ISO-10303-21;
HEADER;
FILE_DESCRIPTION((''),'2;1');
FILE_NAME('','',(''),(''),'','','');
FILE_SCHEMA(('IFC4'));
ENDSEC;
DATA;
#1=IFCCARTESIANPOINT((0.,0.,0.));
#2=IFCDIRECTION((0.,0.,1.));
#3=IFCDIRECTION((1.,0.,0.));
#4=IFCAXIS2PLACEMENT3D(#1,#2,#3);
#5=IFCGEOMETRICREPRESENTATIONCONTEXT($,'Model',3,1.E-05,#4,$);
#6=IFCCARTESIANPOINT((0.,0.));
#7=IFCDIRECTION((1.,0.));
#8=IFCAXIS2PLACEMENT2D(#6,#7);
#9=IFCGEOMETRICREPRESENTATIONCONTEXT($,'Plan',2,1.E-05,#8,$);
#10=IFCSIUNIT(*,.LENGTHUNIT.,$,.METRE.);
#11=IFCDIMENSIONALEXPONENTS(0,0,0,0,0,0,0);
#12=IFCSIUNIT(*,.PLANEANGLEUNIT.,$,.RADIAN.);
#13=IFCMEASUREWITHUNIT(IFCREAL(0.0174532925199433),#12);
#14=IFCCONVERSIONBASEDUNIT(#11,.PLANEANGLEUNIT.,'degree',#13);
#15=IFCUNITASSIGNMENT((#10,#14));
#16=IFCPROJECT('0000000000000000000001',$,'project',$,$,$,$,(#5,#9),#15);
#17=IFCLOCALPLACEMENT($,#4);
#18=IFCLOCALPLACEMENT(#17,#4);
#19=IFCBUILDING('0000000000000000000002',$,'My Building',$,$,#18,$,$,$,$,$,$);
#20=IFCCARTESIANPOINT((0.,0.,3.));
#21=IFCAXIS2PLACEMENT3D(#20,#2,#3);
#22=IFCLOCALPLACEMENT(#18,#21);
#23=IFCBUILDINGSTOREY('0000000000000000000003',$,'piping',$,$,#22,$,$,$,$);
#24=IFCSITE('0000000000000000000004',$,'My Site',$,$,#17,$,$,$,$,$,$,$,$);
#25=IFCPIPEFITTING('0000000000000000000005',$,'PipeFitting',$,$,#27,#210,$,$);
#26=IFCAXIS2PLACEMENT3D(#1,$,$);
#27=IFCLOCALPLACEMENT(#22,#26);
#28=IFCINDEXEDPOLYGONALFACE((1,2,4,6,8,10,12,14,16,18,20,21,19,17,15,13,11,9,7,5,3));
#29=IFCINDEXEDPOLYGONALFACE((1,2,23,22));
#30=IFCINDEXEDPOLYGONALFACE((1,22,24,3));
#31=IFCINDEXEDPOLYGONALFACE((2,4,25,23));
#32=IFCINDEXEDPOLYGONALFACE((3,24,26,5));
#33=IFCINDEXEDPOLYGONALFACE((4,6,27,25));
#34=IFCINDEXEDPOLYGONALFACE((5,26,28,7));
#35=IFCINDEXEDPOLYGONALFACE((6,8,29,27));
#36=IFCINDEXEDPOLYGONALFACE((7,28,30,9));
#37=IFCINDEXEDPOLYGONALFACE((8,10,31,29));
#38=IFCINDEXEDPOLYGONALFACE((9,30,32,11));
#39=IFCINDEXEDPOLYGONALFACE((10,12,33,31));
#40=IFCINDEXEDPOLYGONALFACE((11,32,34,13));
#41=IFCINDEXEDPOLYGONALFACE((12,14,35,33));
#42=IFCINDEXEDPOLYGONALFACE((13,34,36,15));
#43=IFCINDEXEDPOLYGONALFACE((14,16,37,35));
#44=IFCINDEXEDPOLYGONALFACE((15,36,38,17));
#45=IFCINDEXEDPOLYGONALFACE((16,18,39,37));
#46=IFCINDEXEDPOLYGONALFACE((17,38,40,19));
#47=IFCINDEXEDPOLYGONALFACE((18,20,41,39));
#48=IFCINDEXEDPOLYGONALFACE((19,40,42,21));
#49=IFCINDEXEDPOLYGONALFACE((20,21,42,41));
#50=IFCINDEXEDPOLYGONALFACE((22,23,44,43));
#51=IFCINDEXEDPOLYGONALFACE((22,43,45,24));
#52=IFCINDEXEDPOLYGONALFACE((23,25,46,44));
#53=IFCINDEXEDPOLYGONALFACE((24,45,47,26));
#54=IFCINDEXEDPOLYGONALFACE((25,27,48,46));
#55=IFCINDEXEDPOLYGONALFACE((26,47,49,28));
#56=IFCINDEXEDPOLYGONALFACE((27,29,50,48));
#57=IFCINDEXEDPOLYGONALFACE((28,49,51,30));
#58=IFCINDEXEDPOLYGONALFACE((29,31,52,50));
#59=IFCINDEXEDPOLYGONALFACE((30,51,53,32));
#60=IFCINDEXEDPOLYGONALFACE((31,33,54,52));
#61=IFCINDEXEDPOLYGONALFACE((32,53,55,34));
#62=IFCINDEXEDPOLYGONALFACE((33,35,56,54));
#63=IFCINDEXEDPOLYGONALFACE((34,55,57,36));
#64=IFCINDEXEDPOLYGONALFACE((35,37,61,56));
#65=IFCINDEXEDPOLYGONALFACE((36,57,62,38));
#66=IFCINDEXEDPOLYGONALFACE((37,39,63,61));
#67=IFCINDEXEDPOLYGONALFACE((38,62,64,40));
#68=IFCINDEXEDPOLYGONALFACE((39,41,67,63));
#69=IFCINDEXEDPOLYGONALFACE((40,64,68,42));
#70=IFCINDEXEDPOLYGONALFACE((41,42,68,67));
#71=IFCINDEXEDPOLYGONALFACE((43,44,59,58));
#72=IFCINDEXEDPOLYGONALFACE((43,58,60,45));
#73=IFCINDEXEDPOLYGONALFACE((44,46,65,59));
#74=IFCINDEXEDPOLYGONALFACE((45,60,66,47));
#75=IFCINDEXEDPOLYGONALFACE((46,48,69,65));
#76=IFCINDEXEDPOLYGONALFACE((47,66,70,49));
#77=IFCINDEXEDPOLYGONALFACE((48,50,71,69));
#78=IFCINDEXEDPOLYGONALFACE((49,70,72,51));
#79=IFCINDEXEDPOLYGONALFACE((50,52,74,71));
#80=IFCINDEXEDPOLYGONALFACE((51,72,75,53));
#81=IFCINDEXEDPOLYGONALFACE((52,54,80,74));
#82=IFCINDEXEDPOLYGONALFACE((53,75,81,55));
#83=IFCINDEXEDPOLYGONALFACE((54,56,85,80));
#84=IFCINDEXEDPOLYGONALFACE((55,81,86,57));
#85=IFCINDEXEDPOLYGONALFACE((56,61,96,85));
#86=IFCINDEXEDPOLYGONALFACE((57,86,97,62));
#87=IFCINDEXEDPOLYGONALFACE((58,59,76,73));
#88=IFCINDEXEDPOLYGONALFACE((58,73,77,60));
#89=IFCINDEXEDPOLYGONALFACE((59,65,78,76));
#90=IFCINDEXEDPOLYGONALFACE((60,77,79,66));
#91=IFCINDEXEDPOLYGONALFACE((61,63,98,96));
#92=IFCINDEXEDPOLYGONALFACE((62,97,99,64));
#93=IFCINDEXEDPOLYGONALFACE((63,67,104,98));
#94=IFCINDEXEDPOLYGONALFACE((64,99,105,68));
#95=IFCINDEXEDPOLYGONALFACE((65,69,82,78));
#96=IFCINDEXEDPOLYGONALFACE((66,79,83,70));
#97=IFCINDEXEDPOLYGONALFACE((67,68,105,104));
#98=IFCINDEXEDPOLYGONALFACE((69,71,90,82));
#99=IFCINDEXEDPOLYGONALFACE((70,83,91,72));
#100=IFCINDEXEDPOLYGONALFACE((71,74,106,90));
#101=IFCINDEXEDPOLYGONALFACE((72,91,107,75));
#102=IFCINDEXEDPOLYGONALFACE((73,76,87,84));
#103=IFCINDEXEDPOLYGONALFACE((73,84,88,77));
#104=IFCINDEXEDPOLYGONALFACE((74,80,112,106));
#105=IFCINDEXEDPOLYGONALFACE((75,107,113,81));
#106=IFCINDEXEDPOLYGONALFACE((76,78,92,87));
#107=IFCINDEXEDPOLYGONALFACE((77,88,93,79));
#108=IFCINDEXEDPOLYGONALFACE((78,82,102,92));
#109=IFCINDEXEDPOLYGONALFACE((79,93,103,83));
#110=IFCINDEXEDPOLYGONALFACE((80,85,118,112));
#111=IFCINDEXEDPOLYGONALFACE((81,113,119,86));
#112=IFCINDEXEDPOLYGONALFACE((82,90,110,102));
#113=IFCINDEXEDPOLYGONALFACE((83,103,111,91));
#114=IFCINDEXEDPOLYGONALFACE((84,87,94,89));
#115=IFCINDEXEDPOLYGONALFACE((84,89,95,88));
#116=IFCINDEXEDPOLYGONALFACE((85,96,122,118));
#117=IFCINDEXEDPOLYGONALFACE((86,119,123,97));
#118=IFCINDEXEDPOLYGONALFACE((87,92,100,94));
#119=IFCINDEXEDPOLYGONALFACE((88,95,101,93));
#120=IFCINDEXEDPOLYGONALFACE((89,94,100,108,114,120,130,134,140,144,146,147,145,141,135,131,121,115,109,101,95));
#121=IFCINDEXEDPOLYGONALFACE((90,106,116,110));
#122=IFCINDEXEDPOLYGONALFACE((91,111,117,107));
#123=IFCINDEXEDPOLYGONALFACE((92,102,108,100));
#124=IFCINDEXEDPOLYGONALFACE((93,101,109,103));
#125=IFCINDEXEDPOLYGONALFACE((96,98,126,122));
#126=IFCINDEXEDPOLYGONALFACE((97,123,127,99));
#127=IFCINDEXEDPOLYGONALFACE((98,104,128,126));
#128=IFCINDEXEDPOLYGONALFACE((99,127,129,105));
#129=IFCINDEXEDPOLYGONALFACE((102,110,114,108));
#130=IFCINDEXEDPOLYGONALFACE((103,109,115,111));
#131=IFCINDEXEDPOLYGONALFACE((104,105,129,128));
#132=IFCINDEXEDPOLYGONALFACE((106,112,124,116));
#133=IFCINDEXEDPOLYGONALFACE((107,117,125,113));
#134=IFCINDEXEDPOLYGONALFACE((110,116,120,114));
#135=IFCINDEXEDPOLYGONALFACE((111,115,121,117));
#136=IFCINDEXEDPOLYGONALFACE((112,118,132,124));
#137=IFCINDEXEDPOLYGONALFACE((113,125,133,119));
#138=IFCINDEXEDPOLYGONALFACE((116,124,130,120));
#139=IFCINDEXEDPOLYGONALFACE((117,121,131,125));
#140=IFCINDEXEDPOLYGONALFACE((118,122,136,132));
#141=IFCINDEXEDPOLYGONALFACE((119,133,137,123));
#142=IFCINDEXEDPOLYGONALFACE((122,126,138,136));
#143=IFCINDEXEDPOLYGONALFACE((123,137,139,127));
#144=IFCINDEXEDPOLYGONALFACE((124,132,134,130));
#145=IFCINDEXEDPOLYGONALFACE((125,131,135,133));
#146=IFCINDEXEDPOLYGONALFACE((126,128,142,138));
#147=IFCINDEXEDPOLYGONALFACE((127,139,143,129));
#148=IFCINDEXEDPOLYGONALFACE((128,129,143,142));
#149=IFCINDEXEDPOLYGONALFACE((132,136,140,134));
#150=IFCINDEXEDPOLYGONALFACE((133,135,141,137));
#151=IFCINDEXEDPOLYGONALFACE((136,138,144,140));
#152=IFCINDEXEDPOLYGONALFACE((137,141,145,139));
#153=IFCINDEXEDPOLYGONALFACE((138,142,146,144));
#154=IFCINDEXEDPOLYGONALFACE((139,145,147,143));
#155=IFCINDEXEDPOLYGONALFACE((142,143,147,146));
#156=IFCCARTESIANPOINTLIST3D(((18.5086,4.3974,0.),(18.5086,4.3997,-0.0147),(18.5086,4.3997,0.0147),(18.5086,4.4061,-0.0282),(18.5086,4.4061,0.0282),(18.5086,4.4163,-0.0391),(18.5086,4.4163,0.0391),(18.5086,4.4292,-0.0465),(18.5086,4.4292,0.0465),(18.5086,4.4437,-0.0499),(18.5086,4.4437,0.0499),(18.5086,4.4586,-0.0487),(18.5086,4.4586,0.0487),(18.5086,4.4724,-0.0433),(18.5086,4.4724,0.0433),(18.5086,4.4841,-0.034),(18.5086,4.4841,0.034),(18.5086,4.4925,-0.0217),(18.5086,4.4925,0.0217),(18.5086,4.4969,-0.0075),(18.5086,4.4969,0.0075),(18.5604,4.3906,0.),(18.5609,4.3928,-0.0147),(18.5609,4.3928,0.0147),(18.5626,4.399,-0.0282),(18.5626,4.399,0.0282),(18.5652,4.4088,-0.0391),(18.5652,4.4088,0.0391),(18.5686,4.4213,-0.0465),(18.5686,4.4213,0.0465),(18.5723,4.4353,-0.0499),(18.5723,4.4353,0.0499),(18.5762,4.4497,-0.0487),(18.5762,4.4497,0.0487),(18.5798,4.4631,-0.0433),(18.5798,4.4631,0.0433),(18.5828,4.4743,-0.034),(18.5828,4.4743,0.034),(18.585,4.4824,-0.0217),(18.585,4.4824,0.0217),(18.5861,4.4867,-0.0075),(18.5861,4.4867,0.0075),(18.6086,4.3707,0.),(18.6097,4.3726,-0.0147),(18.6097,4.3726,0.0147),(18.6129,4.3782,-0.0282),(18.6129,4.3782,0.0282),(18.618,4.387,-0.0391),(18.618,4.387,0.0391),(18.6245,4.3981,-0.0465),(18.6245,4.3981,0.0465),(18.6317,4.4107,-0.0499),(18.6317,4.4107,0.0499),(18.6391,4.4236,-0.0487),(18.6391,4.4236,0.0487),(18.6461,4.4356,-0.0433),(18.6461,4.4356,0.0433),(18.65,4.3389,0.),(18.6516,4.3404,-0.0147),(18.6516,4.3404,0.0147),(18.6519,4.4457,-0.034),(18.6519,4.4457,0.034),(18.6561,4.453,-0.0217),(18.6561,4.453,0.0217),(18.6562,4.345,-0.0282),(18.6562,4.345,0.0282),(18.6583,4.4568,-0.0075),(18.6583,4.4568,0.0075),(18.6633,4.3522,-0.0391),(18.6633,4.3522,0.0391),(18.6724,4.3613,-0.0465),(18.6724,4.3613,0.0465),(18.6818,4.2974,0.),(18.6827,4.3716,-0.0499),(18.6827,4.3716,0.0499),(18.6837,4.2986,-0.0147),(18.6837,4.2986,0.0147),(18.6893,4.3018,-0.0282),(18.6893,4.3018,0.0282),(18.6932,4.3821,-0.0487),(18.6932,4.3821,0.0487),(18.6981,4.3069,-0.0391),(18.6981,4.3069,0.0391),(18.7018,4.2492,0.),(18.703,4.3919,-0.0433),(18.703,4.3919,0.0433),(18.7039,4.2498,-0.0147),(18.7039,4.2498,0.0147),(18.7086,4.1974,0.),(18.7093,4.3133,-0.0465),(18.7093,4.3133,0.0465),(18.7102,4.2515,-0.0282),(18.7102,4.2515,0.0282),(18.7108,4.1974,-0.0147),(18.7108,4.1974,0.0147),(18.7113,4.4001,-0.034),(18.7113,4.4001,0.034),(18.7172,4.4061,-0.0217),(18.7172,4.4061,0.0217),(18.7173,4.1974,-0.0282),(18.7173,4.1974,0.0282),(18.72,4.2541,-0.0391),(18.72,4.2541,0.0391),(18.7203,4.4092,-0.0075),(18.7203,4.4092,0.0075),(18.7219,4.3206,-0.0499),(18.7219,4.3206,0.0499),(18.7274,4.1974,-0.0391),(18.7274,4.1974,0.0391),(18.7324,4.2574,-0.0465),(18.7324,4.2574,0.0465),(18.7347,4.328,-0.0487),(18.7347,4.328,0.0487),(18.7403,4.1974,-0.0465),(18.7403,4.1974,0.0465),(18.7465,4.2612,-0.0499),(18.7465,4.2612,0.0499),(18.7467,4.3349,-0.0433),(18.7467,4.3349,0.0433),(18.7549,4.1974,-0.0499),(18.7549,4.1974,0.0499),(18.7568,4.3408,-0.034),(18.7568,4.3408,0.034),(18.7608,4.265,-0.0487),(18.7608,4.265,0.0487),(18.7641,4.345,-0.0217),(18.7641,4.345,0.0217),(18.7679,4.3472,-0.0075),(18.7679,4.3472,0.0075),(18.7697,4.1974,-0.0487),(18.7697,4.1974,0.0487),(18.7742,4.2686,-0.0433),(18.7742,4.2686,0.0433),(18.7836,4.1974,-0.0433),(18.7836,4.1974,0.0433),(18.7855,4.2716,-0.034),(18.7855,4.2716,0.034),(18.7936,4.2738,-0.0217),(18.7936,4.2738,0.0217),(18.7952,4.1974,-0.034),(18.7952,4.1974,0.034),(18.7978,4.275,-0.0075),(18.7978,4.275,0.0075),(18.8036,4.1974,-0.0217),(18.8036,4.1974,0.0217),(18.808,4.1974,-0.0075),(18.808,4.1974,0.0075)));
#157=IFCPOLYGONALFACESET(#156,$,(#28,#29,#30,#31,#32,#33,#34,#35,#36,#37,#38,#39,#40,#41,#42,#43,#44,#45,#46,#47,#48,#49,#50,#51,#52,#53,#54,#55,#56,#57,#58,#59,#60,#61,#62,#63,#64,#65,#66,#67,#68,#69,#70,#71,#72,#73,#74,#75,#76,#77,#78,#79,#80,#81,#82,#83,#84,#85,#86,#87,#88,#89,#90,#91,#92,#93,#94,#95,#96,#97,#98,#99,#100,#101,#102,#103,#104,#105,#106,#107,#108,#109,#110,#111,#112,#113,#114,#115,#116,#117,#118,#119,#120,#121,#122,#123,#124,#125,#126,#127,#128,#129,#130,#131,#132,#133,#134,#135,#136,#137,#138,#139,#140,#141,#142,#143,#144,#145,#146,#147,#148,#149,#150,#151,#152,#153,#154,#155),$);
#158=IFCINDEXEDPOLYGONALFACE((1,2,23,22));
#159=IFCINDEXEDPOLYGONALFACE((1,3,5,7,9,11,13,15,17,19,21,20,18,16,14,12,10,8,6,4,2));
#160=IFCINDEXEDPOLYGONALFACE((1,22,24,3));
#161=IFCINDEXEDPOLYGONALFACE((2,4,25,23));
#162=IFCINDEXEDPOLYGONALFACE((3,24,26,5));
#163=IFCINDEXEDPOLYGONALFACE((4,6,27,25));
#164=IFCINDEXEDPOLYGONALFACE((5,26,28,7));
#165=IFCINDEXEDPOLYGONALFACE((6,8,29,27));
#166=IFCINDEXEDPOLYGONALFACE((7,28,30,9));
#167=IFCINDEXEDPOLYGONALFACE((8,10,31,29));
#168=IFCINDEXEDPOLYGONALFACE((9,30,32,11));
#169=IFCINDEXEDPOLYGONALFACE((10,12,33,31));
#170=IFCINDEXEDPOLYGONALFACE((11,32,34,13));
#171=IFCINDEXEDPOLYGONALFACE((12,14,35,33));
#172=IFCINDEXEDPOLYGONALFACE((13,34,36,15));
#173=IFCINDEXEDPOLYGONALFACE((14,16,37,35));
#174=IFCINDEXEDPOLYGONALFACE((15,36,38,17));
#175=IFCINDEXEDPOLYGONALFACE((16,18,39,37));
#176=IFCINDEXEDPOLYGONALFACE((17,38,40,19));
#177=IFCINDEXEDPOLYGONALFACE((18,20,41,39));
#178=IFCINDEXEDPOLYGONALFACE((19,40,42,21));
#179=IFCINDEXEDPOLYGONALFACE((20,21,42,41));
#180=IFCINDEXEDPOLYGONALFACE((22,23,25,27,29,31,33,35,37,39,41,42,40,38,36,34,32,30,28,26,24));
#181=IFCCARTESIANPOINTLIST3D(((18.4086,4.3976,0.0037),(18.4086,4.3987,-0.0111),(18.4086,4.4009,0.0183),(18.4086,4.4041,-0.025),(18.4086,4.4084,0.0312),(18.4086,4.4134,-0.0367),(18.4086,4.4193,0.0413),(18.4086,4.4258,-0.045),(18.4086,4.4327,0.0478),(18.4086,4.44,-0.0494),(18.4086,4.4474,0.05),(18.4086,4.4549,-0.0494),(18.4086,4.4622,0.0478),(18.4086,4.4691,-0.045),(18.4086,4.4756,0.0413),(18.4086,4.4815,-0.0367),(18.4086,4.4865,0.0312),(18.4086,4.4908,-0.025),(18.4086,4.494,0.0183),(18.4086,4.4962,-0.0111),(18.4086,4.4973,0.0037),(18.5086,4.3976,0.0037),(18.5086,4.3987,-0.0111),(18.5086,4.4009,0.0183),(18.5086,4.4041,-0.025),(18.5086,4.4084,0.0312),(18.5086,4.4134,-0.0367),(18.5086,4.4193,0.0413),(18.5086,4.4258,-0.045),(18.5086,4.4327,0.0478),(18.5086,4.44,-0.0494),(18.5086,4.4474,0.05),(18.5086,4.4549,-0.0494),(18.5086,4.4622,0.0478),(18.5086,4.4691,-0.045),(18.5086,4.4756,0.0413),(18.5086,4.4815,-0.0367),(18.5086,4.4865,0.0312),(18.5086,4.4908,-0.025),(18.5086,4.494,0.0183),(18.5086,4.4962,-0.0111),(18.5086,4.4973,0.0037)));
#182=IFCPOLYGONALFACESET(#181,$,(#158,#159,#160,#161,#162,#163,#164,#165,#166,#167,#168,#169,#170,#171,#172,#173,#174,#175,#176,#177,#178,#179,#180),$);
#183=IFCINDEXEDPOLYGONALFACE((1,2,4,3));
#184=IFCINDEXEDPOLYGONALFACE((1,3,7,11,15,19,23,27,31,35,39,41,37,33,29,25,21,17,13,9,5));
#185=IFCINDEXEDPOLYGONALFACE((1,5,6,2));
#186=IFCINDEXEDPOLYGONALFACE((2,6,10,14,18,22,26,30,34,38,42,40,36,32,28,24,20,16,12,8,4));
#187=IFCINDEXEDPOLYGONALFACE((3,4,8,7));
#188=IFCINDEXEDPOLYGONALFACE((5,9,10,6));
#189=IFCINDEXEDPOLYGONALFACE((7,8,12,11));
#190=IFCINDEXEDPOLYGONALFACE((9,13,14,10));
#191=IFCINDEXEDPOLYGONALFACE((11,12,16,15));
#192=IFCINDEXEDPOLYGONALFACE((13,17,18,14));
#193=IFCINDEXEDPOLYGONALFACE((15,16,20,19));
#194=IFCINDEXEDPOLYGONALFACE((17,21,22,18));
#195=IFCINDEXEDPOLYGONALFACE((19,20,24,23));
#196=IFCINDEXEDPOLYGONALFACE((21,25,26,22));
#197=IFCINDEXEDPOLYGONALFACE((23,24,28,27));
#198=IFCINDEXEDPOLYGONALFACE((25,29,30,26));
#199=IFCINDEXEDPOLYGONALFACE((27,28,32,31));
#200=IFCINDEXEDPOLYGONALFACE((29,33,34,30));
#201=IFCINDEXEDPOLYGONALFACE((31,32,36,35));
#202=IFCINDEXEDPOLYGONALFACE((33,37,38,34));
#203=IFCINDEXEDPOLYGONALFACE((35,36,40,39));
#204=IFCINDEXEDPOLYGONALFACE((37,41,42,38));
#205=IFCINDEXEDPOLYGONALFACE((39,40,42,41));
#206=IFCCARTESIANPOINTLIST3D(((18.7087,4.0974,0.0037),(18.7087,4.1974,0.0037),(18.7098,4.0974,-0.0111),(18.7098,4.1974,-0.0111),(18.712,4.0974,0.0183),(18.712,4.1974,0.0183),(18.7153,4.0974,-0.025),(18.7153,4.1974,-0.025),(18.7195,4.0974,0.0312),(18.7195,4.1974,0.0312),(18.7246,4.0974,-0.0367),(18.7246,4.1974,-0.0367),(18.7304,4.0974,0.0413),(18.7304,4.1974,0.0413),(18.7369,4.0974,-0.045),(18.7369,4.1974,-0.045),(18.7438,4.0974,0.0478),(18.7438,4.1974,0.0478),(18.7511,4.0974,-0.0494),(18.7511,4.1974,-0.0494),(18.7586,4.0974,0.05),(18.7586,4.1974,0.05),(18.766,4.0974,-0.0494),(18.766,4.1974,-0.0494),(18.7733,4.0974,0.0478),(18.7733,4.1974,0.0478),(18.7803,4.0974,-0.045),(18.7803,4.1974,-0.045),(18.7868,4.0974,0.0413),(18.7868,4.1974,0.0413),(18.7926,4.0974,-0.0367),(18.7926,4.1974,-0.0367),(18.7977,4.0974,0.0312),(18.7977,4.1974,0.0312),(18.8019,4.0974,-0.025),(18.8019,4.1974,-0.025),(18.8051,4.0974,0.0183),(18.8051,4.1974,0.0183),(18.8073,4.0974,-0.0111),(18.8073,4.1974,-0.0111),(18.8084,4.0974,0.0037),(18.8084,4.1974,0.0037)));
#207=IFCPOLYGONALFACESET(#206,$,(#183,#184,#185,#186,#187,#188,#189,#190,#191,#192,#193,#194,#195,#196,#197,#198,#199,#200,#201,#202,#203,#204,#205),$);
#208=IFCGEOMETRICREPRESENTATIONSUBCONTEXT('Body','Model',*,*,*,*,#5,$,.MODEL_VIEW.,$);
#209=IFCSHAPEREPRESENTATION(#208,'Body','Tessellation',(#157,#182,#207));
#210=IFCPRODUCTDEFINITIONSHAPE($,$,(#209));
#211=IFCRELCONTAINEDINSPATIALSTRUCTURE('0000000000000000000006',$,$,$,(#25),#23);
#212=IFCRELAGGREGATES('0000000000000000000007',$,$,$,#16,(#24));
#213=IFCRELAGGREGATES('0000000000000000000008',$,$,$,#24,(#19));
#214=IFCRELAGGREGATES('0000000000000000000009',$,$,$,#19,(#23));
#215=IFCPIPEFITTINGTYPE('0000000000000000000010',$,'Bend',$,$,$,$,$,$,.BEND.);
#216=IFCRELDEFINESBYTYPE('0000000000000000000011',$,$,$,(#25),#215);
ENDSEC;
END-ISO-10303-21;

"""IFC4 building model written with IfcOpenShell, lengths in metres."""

from ifc_helpers import new_model, entity, si_unit, converted_unit, frame, origin_with_axes, origin_2d_with_axis, place, context, subcontext, project, spatial, circle, extrude, source, transform, mapped, type_object, type_shapes, element, save


model = new_model("IFC4")

# Units and contexts
model_context = context("Model", 3, precision=1e-05, world=origin_with_axes())
plan_context = context("Plan", 2, precision=1e-05, world=origin_2d_with_axis())
body_context = subcontext(model_context, "Body", "Model", "MODEL_VIEW")
ifc_project = project(units=[si_unit("LENGTHUNIT", "METRE"), converted_unit("PLANEANGLEUNIT", "degree", entity("IfcReal", 0.0174532925199433), si_unit("PLANEANGLEUNIT", "RADIAN"), dimensions=[0, 0, 0, 0, 0, 0, 0])], contexts=[model_context, plan_context])

# Site, building, storey
site_placement = place(None, origin_with_axes())
site = spatial("IfcSite", under=ifc_project, at=site_placement, Name="My Site")
building_placement = place(site_placement, origin_with_axes())
building = spatial("IfcBuilding", under=site, at=building_placement, Name="My Building")
storey_placement = place(building_placement, frame((0.0, 0.0, 3.0), z_axis=(0.0, 0.0, 1.0), x_axis=(1.0, 0.0, 0.0)))
storey = spatial("IfcBuildingStorey", under=building, at=storey_placement, Name="piping")

# Pipe fitting
pipe_fitting_type = type_object("IfcPipeFittingType", Name="Bend", PredefinedType="BEND")
shared_shape = source(origin_with_axes(), body_context, "Body", "SolidModel", [
    entity("IfcSweptDiskSolid", entity("IfcIndexedPolyCurve", entity("IfcCartesianPointList3D", [[0.0, 0.0, -0.1], [0.0, -0.0732, -0.2768], [0.0, -0.25, -0.35]]), [entity("IfcArcIndex", [1, 2, 3])]), 0.05),
    extrude(circle(Radius=0.05), origin_with_axes(), (0.0, 0.0, -1.0), 0.1),
    extrude(circle(Radius=0.05), frame((0.0, -0.25, -0.35), z_axis=(0.0, -1.0, 0.0), x_axis=(1.0, 0.0, 0.0)), (0.0, 0.0, 1.0), 0.1),
])
type_shapes(pipe_fitting_type, [shared_shape])
for number, where, z_axis, x_axis, name in (
    (1, (18.4086, 4.4474, 0.0), (-1.0, 0.0, 0.0), (0.0, 0.0, 1.0), "PipeFitting"),
):
    element("IfcPipeFitting", number, at=place(storey_placement, frame(where, z_axis=z_axis, x_axis=x_axis)), inside=storey, type_object=pipe_fitting_type, Name=name, context=body_context, shape_type="MappedRepresentation", body=[
        mapped(shared_shape, transform((0.0, 0.0, 0.0), x_axis=(1.0, 0.0, 0.0), y_axis=(0.0, 1.0, 0.0), z_axis=(0.0, 0.0, 1.0), scale=1.0)),
    ])

save(model, "model.ifc")
